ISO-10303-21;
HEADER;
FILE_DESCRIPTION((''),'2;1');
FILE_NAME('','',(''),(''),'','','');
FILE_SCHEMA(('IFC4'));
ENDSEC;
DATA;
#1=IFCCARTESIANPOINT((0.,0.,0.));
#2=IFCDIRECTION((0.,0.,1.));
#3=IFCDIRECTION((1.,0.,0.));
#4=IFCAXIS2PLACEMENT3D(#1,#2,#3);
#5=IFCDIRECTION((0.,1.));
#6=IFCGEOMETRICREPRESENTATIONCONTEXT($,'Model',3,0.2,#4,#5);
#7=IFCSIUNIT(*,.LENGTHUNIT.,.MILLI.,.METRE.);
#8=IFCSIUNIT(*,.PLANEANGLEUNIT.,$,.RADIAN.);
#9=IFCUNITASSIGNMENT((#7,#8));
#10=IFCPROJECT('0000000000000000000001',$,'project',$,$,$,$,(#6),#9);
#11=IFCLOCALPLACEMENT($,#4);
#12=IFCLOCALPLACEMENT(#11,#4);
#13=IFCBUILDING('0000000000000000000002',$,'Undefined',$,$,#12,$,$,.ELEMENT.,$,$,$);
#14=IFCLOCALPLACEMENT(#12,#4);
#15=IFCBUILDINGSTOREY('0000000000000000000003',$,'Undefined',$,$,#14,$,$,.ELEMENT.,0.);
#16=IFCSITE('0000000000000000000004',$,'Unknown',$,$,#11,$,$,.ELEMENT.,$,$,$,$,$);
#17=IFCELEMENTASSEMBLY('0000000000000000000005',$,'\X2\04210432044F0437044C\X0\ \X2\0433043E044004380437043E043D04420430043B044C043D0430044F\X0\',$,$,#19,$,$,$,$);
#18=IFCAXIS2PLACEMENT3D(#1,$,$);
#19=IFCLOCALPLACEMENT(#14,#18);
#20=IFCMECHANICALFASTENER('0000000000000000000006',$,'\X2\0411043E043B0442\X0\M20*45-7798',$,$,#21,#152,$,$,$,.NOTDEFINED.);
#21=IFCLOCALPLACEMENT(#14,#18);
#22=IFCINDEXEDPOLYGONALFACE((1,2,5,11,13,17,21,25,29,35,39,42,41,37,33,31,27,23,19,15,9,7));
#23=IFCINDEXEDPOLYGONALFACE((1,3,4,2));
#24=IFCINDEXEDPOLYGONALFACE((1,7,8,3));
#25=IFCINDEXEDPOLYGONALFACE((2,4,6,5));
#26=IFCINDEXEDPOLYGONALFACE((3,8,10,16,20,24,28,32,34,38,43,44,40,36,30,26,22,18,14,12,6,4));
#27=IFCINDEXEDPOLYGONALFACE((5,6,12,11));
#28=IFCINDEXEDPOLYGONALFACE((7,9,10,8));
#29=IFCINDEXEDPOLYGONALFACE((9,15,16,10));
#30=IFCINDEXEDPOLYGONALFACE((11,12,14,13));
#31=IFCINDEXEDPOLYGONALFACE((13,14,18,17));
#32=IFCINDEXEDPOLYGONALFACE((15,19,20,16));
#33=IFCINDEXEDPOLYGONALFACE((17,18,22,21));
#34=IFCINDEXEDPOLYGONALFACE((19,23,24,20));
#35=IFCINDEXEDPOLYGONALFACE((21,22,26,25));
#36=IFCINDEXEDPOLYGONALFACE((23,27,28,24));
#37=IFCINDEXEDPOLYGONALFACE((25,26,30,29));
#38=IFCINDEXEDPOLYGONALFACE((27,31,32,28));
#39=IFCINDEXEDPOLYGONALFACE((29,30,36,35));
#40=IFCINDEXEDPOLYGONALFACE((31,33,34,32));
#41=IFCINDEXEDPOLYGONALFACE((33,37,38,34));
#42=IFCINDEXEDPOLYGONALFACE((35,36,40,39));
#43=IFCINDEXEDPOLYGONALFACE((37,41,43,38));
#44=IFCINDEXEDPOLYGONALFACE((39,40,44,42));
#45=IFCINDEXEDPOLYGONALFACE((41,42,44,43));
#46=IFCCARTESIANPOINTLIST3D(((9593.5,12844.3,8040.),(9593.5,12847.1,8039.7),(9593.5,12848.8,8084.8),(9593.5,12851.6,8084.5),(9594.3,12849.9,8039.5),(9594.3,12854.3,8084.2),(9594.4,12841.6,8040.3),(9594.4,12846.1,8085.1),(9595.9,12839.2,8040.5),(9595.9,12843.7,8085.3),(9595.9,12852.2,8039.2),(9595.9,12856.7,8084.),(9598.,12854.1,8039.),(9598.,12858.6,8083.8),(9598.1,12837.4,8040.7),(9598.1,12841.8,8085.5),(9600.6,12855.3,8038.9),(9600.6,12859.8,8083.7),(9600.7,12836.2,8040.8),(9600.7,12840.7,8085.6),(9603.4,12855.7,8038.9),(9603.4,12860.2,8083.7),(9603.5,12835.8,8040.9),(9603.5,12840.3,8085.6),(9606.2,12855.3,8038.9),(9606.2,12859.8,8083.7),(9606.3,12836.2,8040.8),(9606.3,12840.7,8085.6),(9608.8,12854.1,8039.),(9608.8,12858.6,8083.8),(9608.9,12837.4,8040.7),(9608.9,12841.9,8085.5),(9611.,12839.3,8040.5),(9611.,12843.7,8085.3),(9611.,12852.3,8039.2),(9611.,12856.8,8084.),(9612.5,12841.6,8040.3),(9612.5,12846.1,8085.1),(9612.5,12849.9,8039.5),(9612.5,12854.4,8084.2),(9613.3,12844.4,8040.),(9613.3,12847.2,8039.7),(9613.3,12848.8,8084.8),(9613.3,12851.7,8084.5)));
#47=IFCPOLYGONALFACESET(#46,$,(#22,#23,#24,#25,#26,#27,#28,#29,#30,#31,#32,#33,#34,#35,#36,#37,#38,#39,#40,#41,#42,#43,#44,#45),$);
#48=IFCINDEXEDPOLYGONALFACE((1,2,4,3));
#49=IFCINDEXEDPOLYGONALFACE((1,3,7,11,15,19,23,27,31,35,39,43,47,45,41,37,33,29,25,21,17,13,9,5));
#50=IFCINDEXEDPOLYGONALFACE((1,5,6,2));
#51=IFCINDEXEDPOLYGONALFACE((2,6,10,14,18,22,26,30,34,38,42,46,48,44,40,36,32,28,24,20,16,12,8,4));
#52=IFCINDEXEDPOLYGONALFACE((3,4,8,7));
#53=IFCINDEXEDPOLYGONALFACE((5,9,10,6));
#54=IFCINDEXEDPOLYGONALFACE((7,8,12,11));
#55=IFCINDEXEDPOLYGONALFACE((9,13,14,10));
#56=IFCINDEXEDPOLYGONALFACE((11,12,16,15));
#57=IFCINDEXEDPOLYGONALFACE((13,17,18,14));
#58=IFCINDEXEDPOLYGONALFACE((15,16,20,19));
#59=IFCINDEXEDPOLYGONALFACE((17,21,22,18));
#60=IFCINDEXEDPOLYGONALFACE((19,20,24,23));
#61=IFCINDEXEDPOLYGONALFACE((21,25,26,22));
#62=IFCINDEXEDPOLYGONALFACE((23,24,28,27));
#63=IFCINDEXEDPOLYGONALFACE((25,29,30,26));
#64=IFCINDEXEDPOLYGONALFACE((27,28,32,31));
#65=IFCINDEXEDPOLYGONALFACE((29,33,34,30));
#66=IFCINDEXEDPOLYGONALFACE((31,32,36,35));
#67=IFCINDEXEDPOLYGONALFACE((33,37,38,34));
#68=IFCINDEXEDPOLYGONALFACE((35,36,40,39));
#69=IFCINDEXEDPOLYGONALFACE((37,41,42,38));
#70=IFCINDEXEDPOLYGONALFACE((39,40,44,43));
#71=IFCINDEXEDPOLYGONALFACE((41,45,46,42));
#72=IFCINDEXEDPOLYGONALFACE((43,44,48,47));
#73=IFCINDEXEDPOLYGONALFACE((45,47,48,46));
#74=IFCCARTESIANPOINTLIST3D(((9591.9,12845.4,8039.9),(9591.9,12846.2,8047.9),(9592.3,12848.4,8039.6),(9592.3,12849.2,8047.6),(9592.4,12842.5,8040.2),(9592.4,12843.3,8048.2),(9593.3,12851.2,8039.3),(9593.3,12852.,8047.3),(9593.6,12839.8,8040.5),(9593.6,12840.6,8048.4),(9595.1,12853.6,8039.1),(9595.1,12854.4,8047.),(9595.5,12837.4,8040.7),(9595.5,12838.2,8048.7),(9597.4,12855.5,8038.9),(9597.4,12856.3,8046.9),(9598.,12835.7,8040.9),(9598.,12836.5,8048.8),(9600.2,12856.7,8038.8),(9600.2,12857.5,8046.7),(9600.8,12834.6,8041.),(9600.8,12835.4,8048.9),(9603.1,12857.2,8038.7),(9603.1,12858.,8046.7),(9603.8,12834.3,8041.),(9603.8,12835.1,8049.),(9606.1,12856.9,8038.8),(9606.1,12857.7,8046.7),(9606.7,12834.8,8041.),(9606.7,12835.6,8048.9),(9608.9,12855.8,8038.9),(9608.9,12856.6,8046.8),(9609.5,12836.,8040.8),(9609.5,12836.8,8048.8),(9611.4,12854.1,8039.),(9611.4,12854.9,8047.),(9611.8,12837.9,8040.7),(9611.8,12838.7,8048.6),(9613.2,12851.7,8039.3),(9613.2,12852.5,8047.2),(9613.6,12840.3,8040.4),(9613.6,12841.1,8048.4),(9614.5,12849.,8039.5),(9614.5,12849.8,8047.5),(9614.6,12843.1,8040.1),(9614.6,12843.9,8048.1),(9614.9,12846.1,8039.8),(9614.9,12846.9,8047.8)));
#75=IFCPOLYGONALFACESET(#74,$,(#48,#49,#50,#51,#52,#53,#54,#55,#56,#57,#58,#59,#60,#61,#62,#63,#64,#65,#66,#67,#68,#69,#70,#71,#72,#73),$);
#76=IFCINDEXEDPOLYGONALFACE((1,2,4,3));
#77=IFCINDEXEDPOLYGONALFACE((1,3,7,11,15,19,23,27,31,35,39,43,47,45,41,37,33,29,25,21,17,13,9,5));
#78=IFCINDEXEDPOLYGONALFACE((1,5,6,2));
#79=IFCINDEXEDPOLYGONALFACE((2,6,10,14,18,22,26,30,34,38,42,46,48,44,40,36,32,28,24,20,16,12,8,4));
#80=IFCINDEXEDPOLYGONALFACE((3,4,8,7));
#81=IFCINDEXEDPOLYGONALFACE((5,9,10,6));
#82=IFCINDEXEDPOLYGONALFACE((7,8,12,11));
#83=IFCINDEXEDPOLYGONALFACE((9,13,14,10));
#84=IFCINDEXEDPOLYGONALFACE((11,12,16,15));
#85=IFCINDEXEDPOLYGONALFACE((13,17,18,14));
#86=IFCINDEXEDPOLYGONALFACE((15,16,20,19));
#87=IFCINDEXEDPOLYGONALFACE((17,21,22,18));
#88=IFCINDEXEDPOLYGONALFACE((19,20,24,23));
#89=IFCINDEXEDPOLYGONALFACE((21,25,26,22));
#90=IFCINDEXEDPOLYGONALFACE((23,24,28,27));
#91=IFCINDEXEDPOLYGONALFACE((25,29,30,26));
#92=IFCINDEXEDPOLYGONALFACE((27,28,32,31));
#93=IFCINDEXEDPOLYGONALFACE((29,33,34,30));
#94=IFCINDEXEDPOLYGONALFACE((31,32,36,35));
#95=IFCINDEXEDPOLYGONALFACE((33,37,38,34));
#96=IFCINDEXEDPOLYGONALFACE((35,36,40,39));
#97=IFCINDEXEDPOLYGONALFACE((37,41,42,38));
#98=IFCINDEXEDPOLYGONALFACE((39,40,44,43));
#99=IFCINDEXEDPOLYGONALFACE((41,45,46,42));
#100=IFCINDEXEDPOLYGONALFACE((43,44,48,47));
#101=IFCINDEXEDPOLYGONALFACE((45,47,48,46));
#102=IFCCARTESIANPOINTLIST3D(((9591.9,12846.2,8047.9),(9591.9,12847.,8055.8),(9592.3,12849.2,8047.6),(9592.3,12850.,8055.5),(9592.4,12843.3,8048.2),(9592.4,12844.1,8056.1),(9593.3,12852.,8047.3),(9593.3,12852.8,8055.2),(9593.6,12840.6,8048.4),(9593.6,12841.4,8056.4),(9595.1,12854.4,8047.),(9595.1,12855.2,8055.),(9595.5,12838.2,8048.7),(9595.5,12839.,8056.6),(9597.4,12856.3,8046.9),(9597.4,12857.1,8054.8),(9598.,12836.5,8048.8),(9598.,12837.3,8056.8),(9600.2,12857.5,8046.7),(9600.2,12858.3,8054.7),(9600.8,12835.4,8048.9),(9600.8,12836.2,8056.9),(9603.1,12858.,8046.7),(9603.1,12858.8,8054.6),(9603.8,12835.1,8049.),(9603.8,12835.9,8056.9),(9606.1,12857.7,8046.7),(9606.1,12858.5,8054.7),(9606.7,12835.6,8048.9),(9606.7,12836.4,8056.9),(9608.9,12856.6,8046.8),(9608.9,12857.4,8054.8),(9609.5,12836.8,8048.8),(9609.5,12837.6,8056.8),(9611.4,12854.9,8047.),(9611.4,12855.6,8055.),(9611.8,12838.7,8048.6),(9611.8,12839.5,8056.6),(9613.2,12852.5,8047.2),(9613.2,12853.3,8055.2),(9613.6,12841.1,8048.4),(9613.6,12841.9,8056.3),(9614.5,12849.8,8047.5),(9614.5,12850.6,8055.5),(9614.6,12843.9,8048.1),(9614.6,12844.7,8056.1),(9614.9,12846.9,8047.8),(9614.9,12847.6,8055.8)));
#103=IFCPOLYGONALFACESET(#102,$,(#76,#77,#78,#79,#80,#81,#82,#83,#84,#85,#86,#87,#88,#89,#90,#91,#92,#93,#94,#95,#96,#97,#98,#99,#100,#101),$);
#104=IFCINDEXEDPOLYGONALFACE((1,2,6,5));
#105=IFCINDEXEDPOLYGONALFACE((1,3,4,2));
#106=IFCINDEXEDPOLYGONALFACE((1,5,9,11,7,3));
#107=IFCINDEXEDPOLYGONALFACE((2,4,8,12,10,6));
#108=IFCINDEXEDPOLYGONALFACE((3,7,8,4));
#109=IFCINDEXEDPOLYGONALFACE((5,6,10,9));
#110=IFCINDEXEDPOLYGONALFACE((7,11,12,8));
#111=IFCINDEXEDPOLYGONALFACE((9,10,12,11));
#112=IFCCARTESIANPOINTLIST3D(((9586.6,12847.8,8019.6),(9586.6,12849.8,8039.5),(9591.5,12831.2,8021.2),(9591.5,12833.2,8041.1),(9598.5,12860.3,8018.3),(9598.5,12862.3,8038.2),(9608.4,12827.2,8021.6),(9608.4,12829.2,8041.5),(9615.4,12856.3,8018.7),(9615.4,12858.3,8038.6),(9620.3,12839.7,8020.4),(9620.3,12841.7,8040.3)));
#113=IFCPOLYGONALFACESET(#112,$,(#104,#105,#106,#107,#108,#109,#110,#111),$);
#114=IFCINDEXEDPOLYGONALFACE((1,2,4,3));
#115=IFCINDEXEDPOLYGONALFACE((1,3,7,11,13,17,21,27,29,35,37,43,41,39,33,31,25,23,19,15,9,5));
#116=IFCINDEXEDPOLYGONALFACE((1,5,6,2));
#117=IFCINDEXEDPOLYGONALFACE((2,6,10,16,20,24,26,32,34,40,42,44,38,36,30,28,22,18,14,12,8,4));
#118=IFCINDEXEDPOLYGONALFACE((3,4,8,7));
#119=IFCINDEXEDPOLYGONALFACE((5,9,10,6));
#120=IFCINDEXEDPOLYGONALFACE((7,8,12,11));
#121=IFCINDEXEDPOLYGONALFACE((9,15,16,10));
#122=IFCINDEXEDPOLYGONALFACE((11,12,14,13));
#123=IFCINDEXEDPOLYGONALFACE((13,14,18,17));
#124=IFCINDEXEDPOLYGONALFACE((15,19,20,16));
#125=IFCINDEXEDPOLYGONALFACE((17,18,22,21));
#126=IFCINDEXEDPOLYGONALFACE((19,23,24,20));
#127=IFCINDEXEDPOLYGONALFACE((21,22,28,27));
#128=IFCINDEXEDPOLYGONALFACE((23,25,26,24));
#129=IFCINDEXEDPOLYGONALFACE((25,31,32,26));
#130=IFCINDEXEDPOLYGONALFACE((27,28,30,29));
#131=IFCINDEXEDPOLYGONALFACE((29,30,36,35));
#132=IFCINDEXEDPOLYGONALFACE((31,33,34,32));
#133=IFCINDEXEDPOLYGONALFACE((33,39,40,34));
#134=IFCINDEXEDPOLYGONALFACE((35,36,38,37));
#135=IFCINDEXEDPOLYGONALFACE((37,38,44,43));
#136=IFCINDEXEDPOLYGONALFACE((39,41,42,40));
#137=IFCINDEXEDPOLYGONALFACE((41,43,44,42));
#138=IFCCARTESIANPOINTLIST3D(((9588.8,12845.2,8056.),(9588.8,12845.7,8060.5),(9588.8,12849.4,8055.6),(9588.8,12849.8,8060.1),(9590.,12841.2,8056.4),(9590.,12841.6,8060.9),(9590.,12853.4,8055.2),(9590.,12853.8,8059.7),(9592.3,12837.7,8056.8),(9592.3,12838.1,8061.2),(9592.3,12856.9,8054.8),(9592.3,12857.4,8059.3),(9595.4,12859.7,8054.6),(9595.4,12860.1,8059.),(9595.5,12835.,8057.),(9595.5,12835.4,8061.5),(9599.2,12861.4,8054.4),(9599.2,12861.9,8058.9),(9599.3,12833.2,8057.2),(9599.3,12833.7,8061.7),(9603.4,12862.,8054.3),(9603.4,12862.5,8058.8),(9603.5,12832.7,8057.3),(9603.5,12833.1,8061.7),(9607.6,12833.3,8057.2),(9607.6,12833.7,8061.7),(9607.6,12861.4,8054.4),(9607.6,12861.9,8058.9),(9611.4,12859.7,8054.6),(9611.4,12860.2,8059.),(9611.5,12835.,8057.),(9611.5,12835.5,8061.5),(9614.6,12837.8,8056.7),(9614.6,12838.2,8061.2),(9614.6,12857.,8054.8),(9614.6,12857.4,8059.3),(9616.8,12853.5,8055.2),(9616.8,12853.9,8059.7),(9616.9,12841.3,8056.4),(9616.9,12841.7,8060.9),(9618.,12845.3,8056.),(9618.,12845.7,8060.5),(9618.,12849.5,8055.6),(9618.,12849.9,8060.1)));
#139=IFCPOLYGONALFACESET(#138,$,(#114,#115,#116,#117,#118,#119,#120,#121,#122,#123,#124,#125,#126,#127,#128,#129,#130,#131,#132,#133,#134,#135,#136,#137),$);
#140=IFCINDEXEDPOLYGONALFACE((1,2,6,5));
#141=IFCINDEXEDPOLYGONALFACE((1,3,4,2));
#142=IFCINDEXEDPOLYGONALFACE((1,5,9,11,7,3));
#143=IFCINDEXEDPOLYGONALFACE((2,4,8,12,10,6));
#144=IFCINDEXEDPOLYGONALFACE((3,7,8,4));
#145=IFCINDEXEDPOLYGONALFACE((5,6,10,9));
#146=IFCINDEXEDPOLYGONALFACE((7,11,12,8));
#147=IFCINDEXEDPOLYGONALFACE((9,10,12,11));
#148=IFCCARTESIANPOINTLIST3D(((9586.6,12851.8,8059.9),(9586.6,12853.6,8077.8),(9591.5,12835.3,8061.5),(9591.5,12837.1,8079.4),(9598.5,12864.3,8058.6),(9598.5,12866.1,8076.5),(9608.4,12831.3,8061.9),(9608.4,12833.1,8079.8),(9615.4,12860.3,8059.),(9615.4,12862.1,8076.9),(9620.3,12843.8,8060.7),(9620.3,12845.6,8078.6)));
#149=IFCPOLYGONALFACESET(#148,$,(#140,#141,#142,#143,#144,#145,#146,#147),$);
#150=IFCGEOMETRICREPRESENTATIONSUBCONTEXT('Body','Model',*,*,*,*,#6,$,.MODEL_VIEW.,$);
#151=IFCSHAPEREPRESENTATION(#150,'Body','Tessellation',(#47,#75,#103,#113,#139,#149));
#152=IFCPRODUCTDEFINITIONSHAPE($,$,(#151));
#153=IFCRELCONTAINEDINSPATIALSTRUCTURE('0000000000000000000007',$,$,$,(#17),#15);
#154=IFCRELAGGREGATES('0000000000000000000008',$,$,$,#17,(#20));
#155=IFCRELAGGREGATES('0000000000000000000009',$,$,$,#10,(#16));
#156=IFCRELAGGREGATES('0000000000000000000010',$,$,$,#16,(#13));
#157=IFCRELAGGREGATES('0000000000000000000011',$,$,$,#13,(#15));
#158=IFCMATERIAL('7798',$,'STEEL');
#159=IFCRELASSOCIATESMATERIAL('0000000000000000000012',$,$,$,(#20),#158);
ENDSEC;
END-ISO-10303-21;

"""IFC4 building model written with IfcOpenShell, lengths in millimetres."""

from ifc_helpers import new_model, si_unit, direction, frame, origin_with_axes, place, context, subcontext, project, spatial, line, arc, indexed_curve, outline, extrude, source, transform, mapped, material, element, aggregate, save


model = new_model("IFC4")

# Units and contexts
model_context = context("Model", 3, precision=0.2, world=origin_with_axes(), true_north=direction((0.0, 1.0)))
body_context = subcontext(model_context, "Body", "Model", "MODEL_VIEW")
ifc_project = project(units=[si_unit("LENGTHUNIT", "METRE", prefix="MILLI"), si_unit("PLANEANGLEUNIT", "RADIAN")], contexts=[model_context])

# Site, building, storey
site_placement = place(None, origin_with_axes())
site = spatial("IfcSite", under=ifc_project, at=site_placement, Name="Unknown", CompositionType="ELEMENT")
building_placement = place(site_placement, origin_with_axes())
building = spatial("IfcBuilding", under=site, at=building_placement, Name="Undefined", CompositionType="ELEMENT")
storey_placement = place(building_placement, origin_with_axes())
storey = spatial("IfcBuildingStorey", under=building, at=storey_placement, Name="Undefined", CompositionType="ELEMENT", Elevation=0.0)

# Element assembly
assembly_1_placement = place(storey_placement, frame((8657.9, 12567.5, 8079.8), z_axis=(0.28473, -0.95385, 0.095385), x_axis=(0.958608, 0.283317, -0.028332)))
assembly_1 = element("IfcElementAssembly", 1, at=assembly_1_placement, inside=storey, Name="Связь горизонтальная")

# Shared definitions
ifc_material_1 = material(Name="7798", Category="STEEL")

# Mechanical fastener
shared_shape_1 = source(origin_with_axes(), body_context, "Body", "SweptSolid", [
    extrude(outline(indexed_curve([(10.0, 0.0), (0.0, 10.0), (-10.0, 0.0), (0.0, -10.0)], segments=[arc(1, 2, 3), arc(3, 4, 1)])), frame((0.0, 0.0, 12.0), z_axis=(0.0, 0.0, -1.0), x_axis=(0.0, 1.0, 0.0)), (0.0, 0.0, 1.0), 45.0),
    extrude(outline(indexed_curve([(0.0, 11.5), (8.1, 8.1), (11.5, 0.0), (8.1, -8.1), (0.0, -11.5), (-1.0, -11.5), (-11.5, 0.0), (-8.1, 8.1)], segments=[arc(1, 2, 3), arc(3, 4, 5), arc(5, 6, 7), arc(7, 8, 1)])), frame((0.0, 0.0, 12.0), z_axis=(0.0, 0.0, -1.0), x_axis=(0.0, 1.0, 0.0)), (0.0, 0.0, 1.0), 8.0),
    extrude(outline(indexed_curve([(0.0, 11.5), (8.1, 8.1), (11.5, 0.0), (8.1, -8.1), (0.0, -11.5), (-1.0, -11.5), (-11.5, 0.0), (-8.1, 8.1)], segments=[arc(1, 2, 3), arc(3, 4, 5), arc(5, 6, 7), arc(7, 8, 1)])), frame((0.0, 0.0, 4.0), z_axis=(0.0, 0.0, -1.0), x_axis=(0.0, 1.0, 0.0)), (0.0, 0.0, 1.0), 8.0),
    extrude(outline(indexed_curve([(17.3, 0.0), (8.7, 15.0), (-8.7, 15.0), (-17.3, 0.0), (-8.7, -15.0), (8.7, -15.0)], segments=[line(1, 2, 3, 4, 5, 6, 1)])), frame((0.0, 0.0, 32.0), z_axis=(0.0, 0.0, -1.0), x_axis=(0.0, 1.0, 0.0)), (0.0, 0.0, 1.0), 20.0),
    extrude(outline(indexed_curve([(14.8, 0.0), (0.0, 14.8), (-14.8, 0.0), (0.0, -14.8)], segments=[arc(1, 2, 3), arc(3, 4, 1)])), frame((0.0, 0.0, -4.0), z_axis=(0.0, 0.0, -1.0), x_axis=(0.0, 1.0, 0.0)), (0.0, 0.0, 1.0), 4.5),
    extrude(outline(indexed_curve([(17.3, 0.0), (8.7, 15.0), (-8.7, 15.0), (-17.3, 0.0), (-8.7, -15.0), (8.7, -15.0)], segments=[line(1, 2, 3, 4, 5, 6, 1)])), frame((0.0, 0.0, -8.5), z_axis=(0.0, 0.0, -1.0), x_axis=(0.0, 1.0, 0.0)), (0.0, 0.0, 1.0), 18.0),
])
mechanical_fastener_1_placement = place(assembly_1_placement, frame((986.3, 0.0, 0.0), z_axis=(0.0, -1.0, 0.0), x_axis=(-1.0, 0.0, 0.0)))
mechanical_fastener_1 = element("IfcMechanicalFastener", 2, at=mechanical_fastener_1_placement, material=ifc_material_1, Name="БолтM20*45-7798", PredefinedType="NOTDEFINED", context=body_context, shape_type="MappedRepresentation", body=[
    mapped(shared_shape_1, transform((0.0, 0.0, 0.0))),
])
aggregate(assembly_1, [mechanical_fastener_1])

save(model, "model.ifc")
